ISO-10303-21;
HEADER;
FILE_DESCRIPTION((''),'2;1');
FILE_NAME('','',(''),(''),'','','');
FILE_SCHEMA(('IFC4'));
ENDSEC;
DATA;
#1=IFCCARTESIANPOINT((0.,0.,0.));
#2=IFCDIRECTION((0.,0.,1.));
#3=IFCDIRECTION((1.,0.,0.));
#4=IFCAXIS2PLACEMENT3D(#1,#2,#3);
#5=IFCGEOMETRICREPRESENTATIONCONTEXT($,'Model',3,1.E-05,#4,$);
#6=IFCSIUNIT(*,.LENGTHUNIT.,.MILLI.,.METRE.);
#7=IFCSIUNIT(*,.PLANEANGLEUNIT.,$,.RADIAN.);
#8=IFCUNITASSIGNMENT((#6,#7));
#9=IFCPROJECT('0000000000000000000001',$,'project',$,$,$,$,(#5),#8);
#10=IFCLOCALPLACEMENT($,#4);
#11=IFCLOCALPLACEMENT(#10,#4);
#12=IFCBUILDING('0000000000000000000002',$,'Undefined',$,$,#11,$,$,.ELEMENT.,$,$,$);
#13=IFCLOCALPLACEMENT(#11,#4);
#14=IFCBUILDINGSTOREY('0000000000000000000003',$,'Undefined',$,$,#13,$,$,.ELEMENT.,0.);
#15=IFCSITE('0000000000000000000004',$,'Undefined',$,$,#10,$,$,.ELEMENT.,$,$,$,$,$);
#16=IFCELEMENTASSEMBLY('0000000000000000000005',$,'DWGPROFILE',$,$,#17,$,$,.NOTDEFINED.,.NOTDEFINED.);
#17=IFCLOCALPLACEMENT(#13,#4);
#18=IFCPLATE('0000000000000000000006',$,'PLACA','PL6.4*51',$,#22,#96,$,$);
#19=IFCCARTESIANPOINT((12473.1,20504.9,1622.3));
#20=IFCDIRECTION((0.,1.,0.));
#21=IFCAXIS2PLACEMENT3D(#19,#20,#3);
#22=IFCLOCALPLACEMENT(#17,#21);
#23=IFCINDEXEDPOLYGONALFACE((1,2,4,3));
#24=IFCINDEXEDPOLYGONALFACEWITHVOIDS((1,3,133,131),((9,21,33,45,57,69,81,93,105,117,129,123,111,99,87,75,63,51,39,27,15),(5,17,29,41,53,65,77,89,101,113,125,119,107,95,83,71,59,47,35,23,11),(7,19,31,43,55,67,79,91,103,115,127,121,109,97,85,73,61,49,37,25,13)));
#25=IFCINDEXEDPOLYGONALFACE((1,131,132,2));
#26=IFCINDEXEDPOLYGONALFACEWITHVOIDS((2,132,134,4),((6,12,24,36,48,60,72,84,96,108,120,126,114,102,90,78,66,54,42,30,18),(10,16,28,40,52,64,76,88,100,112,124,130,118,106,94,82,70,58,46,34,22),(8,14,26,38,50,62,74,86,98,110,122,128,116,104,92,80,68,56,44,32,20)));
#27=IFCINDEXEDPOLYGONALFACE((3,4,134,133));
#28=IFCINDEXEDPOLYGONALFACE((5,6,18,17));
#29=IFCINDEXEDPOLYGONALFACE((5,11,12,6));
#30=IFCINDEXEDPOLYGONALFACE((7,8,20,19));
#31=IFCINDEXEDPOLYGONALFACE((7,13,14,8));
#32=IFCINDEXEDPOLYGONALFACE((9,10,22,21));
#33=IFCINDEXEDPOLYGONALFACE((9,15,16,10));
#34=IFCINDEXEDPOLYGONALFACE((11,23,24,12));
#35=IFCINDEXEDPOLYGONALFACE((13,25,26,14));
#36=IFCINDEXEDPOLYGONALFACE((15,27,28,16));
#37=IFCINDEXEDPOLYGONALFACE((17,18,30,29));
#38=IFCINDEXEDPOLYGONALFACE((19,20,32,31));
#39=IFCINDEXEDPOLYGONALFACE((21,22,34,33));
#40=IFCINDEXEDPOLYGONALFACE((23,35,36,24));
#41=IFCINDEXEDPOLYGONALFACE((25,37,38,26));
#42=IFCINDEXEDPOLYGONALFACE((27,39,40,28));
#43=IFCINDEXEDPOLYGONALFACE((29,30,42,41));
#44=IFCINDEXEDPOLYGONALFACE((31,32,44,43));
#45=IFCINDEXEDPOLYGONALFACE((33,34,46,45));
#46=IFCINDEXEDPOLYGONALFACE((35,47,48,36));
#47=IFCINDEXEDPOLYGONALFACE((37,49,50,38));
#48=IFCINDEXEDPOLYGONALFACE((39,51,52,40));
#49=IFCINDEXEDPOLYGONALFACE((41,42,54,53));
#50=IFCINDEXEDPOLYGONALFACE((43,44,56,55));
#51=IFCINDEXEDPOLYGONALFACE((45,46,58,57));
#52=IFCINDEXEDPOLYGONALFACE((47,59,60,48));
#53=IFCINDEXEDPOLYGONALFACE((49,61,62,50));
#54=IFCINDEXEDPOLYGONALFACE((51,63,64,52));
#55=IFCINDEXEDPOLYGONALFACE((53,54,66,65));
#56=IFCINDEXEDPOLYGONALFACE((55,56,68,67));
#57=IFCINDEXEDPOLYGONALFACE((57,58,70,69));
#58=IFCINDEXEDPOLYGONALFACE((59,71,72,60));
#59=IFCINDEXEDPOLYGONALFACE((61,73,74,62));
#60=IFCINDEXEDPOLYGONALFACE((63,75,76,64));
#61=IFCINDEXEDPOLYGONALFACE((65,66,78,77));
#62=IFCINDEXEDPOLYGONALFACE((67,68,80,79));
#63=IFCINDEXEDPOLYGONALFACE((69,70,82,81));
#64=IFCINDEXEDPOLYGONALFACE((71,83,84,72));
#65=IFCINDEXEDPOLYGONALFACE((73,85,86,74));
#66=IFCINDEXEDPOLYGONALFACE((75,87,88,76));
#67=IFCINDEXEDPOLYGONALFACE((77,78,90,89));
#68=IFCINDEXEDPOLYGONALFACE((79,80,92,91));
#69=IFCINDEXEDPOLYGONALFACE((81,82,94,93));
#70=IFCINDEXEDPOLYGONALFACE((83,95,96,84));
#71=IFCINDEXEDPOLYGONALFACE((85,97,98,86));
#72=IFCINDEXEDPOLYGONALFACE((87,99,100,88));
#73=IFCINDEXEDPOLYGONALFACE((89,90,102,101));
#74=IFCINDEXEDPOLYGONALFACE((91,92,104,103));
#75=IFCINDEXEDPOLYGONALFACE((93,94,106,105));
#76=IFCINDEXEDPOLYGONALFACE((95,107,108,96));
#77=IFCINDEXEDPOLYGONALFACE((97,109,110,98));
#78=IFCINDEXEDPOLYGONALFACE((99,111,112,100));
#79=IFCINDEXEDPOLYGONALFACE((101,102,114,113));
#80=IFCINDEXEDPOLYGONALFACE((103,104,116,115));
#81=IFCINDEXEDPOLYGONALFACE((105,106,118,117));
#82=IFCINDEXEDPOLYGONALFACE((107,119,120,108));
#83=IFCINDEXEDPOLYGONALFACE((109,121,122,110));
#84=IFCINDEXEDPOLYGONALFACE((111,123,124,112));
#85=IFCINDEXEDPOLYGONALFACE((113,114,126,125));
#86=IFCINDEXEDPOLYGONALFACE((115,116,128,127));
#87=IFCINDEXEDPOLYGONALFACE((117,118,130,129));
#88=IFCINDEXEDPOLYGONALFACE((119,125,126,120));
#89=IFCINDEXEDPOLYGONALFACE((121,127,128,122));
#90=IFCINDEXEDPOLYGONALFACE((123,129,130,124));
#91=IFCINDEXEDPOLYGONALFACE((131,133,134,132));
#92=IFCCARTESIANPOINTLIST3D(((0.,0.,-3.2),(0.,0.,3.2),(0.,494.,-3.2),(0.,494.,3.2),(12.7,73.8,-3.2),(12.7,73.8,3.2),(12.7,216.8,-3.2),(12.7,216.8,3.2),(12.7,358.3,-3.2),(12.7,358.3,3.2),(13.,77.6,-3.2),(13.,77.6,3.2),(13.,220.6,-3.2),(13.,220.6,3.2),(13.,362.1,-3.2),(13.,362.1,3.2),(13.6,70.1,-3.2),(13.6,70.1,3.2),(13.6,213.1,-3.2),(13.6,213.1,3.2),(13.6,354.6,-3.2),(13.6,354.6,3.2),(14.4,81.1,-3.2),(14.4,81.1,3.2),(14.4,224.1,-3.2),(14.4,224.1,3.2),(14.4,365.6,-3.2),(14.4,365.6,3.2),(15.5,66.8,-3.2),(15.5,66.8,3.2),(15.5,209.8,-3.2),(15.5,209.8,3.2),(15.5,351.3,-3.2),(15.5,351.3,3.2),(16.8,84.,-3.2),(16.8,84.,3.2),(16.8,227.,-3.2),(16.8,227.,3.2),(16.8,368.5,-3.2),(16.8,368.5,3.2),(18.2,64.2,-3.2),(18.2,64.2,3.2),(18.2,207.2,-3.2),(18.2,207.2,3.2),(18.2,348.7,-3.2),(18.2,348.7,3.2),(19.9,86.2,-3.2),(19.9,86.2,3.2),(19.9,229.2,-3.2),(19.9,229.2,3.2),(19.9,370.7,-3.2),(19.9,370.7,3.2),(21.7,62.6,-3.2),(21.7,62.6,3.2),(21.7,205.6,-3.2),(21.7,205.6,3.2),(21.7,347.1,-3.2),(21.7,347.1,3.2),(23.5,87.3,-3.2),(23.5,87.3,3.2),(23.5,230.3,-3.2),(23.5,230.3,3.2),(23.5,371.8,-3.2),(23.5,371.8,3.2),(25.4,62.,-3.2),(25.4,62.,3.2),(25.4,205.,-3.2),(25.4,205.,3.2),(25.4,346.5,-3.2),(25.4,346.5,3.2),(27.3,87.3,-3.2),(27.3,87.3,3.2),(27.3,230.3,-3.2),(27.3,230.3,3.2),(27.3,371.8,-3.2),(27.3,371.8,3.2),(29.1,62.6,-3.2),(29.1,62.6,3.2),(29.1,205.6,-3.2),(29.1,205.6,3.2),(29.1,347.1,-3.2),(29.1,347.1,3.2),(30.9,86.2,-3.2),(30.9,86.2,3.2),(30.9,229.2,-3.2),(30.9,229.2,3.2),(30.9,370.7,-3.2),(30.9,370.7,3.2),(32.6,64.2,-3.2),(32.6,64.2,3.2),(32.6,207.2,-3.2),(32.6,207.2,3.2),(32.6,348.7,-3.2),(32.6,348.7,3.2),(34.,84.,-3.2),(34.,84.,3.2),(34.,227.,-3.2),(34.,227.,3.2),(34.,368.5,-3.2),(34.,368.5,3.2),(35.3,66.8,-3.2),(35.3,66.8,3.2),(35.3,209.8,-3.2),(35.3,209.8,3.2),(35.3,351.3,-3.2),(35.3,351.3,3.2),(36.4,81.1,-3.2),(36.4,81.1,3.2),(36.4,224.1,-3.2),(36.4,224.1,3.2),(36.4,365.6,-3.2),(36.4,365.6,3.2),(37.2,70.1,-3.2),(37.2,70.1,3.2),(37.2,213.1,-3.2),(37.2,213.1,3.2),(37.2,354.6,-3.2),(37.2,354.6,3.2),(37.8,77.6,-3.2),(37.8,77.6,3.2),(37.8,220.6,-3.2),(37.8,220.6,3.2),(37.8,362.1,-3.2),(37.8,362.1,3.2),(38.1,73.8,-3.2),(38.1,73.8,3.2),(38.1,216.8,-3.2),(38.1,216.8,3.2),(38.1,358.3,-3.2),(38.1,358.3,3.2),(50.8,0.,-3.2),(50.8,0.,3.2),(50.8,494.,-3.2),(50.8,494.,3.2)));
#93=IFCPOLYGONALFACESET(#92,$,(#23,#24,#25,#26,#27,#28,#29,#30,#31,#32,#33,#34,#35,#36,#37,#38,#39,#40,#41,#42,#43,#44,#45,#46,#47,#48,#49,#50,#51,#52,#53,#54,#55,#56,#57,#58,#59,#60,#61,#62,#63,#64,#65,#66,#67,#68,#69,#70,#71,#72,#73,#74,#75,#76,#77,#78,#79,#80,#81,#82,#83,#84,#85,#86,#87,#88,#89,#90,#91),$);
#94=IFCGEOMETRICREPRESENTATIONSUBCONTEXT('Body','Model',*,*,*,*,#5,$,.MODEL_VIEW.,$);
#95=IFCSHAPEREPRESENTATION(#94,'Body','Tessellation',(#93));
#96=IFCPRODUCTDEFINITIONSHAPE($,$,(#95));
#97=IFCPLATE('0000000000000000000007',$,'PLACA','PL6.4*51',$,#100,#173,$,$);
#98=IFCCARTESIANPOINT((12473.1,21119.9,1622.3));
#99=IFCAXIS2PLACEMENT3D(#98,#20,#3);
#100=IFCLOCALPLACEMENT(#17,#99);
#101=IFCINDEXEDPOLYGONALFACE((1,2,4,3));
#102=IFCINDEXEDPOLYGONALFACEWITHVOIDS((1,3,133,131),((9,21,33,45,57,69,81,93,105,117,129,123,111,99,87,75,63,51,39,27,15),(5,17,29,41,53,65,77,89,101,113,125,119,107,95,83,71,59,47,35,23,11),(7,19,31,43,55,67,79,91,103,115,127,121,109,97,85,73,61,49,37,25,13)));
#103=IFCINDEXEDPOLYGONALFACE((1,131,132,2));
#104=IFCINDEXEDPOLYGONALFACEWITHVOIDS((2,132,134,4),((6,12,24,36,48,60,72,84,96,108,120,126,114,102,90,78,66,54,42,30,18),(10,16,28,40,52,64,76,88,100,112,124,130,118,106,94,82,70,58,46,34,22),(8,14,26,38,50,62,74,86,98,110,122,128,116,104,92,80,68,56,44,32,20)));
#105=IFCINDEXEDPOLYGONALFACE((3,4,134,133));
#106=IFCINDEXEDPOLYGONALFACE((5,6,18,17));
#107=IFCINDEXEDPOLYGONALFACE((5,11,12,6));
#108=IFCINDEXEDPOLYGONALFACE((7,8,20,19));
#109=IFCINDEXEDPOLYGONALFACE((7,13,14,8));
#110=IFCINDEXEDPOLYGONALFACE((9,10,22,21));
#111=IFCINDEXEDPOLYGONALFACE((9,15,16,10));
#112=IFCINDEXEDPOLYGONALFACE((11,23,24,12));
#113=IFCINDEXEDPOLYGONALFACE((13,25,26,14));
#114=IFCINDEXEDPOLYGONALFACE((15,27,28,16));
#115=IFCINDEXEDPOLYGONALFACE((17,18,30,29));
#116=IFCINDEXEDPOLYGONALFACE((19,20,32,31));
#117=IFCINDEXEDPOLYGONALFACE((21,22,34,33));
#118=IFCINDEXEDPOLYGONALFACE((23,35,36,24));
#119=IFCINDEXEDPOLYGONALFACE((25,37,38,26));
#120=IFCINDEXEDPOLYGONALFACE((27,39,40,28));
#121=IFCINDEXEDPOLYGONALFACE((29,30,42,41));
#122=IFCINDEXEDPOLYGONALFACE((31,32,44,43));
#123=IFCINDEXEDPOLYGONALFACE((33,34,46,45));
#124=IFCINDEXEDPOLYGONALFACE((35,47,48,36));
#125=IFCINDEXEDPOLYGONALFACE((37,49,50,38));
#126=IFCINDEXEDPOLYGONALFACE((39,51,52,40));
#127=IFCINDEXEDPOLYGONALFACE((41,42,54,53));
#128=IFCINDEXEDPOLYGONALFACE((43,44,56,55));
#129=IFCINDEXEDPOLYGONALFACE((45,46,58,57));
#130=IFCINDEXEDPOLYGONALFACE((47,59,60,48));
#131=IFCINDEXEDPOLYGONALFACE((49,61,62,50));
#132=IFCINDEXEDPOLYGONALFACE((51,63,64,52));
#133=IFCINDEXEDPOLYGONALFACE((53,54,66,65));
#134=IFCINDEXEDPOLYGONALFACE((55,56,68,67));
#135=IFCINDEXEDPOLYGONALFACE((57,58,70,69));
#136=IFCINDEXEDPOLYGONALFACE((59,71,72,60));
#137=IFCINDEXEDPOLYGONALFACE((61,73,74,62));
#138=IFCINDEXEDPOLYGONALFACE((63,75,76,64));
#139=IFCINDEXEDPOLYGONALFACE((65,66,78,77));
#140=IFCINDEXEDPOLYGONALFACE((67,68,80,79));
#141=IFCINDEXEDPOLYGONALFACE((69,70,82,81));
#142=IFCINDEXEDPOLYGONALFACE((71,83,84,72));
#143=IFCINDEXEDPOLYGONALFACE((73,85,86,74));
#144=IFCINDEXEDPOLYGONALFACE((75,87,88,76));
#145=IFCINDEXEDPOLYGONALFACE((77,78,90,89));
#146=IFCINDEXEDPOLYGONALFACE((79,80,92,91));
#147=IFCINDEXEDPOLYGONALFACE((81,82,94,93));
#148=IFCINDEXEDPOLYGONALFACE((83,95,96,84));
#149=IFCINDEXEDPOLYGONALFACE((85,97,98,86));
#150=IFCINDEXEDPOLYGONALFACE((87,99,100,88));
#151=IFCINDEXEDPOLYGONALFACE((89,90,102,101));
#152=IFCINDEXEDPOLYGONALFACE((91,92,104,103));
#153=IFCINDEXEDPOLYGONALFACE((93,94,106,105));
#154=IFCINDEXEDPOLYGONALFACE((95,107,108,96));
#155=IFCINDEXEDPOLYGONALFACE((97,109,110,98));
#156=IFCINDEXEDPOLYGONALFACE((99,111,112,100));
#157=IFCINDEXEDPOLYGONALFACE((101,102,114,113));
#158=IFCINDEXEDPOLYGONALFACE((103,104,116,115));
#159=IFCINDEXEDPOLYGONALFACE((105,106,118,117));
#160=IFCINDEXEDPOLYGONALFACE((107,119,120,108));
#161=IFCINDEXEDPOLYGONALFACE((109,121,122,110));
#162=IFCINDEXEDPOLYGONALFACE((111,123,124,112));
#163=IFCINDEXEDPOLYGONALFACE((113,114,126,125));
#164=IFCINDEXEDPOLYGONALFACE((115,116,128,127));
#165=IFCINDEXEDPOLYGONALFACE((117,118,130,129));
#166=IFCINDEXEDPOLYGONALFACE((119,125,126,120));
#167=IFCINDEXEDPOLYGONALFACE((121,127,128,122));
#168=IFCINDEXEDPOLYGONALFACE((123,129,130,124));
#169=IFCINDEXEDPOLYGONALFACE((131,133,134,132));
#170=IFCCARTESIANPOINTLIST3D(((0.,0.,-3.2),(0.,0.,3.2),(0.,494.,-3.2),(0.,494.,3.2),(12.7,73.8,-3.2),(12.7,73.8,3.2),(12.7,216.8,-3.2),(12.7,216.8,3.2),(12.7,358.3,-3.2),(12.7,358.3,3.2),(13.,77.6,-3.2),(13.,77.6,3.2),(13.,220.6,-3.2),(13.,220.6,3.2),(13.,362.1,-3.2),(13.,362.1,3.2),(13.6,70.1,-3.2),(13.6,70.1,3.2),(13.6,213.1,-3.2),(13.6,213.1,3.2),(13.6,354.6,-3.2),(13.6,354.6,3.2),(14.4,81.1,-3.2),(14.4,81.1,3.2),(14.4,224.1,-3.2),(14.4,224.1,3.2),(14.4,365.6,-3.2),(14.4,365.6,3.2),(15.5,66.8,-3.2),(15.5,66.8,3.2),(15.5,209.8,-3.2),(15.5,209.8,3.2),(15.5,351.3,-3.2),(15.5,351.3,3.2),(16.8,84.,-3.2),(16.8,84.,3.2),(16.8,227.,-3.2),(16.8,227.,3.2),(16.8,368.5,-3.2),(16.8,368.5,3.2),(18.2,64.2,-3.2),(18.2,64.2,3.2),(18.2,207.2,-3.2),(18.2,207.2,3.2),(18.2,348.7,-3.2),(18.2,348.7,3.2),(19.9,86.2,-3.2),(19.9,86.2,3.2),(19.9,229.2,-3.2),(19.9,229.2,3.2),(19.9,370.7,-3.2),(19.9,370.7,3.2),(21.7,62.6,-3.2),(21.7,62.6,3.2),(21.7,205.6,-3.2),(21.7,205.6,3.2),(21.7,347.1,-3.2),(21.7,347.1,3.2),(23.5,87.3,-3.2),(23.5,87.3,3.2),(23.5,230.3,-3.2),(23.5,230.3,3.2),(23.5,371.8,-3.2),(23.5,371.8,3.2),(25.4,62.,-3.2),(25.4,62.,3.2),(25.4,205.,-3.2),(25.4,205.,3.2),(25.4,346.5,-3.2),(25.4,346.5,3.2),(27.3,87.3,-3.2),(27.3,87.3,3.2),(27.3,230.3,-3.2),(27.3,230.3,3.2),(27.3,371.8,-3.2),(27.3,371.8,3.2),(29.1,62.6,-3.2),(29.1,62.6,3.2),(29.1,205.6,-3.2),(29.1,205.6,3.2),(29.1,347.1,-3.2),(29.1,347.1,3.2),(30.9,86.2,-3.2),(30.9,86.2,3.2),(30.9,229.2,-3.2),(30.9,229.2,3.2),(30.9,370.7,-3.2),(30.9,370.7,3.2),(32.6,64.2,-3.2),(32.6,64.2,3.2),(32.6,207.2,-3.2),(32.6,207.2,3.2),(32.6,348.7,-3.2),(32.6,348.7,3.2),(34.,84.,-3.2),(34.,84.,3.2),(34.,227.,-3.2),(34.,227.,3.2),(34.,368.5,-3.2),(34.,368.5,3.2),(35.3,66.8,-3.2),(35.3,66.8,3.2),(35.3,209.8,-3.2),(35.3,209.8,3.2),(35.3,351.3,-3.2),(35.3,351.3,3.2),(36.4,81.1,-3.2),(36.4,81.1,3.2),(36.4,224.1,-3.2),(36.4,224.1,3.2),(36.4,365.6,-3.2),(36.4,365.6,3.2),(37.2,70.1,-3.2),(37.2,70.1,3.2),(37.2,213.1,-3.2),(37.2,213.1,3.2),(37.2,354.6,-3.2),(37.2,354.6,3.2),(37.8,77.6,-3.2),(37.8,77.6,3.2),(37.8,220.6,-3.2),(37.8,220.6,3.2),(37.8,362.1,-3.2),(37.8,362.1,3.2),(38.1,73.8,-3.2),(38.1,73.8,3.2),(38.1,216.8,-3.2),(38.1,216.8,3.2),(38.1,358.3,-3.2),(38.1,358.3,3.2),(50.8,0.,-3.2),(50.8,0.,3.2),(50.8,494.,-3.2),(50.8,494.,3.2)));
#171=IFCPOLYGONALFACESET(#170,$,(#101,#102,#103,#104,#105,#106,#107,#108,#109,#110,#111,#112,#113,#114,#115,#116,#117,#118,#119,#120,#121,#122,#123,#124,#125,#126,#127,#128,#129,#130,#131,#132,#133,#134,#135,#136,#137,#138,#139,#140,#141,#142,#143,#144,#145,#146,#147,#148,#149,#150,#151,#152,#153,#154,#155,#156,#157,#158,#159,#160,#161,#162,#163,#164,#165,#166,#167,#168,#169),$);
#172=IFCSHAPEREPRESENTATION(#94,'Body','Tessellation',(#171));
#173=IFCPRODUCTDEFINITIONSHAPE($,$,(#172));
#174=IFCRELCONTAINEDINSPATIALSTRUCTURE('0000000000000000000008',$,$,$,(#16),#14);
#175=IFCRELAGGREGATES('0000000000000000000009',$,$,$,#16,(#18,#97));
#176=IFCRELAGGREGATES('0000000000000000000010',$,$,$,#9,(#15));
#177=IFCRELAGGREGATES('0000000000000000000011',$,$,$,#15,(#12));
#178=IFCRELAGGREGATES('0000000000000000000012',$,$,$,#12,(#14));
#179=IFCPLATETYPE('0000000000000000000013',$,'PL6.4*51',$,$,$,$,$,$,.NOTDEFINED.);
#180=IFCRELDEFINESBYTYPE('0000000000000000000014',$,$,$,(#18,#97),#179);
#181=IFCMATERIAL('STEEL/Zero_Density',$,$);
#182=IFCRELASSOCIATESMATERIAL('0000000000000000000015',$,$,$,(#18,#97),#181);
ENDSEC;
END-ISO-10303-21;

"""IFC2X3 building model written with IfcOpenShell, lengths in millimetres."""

from ifc_helpers import new_model, si_unit, frame, origin_with_axes, origin_2d_with_axis, place, context, subcontext, project, spatial, polyline, circle, outline, extrude, boolean, material, type_object, element, aggregate, save


model = new_model("IFC2X3")

# Units and contexts
model_context = context("Model", 3, precision=1e-05, world=origin_with_axes())
body_context = subcontext(model_context, "Body", "Model", "MODEL_VIEW")
ifc_project = project(units=[si_unit("LENGTHUNIT", "METRE", prefix="MILLI"), si_unit("PLANEANGLEUNIT", "RADIAN")], contexts=[model_context])

# Site, building, storey
site_placement = place(None, origin_with_axes())
site = spatial("IfcSite", under=ifc_project, at=site_placement, Name="Undefined", CompositionType="ELEMENT")
building_placement = place(site_placement, origin_with_axes())
building = spatial("IfcBuilding", under=site, at=building_placement, Name="Undefined", CompositionType="ELEMENT")
storey_placement = place(building_placement, origin_with_axes())
storey = spatial("IfcBuildingStorey", under=building, at=storey_placement, Name="Undefined", CompositionType="ELEMENT", Elevation=0.0)

# Element assembly
assembly_1_placement = place(storey_placement, origin_with_axes())
assembly_1 = element("IfcElementAssembly", 1, at=assembly_1_placement, inside=storey, Name="DWGPROFILE", AssemblyPlace="NOTDEFINED", PredefinedType="NOTDEFINED")
ifc_material_1 = material(Name="STEEL/Zero_Density")

# Plates
plate_type_1 = type_object("IfcPlateType", Name="PL6.4*51", PredefinedType="NOTDEFINED")
plate_1_placement = place(assembly_1_placement, frame((12473.1, 20504.9, 1622.3), z_axis=(0.0, 1.0, 0.0), x_axis=(1.0, 0.0, 0.0)))
plate_1 = element("IfcPlate", 2, at=plate_1_placement, type_object=plate_type_1, material=ifc_material_1, Name="PLACA", Description="PL6.4*51", context=body_context, shape_type="CSG", body=[
    boolean("DIFFERENCE", boolean("DIFFERENCE", boolean("DIFFERENCE", extrude(outline(polyline([(0.0, 0.0), (50.8, 0.0), (50.8, 494.0), (0.0, 494.0), (0.0, 0.0)])), frame((0.0, 0.0, -3.2), z_axis=(0.0, 0.0, 1.0), x_axis=(1.0, 0.0, 0.0)), (0.0, 0.0, 1.0), 6.4), extrude(circle(Radius=12.7, at=origin_2d_with_axis()), frame((25.4, 74.7, 100.0), z_axis=(0.0, 0.000001, -1.0), x_axis=(0.0, -1.0, 0.0)), (0.0, 0.0, 1.0), 200.0)), extrude(circle(Radius=12.7, at=origin_2d_with_axis()), frame((25.4, 217.7, 100.0), z_axis=(0.0, 0.000001, -1.0), x_axis=(0.0, -1.0, 0.0)), (0.0, 0.0, 1.0), 200.0)), extrude(circle(Radius=12.7, at=origin_2d_with_axis()), frame((25.4, 359.2, 100.0), z_axis=(0.0, 0.000001, -1.0), x_axis=(0.0, -1.0, 0.0)), (0.0, 0.0, 1.0), 200.0)),
])
plate_2_placement = place(assembly_1_placement, frame((12473.1, 21119.9, 1622.3), z_axis=(0.0, 1.0, 0.0), x_axis=(1.0, 0.0, 0.0)))
plate_2 = element("IfcPlate", 3, at=plate_2_placement, type_object=plate_type_1, material=ifc_material_1, Name="PLACA", Description="PL6.4*51", context=body_context, shape_type="CSG", body=[
    boolean("DIFFERENCE", boolean("DIFFERENCE", boolean("DIFFERENCE", extrude(outline(polyline([(0.0, 0.0), (50.8, 0.0), (50.8, 494.0), (0.0, 494.0), (0.0, 0.0)])), frame((0.0, 0.0, -3.2), z_axis=(0.0, 0.0, 1.0), x_axis=(1.0, 0.0, 0.0)), (0.0, 0.0, 1.0), 6.4), extrude(circle(Radius=12.7, at=origin_2d_with_axis()), frame((25.4, 74.7, 100.0), z_axis=(0.0, 0.000001, -1.0), x_axis=(0.0, -1.0, 0.0)), (0.0, 0.0, 1.0), 200.0)), extrude(circle(Radius=12.7, at=origin_2d_with_axis()), frame((25.4, 217.7, 100.0), z_axis=(0.0, 0.000001, -1.0), x_axis=(0.0, -1.0, 0.0)), (0.0, 0.0, 1.0), 200.0)), extrude(circle(Radius=12.7, at=origin_2d_with_axis()), frame((25.4, 359.2, 100.0), z_axis=(0.0, 0.000001, -1.0), x_axis=(0.0, -1.0, 0.0)), (0.0, 0.0, 1.0), 200.0)),
])
aggregate(assembly_1, [plate_1, plate_2])

save(model, "model.ifc")
